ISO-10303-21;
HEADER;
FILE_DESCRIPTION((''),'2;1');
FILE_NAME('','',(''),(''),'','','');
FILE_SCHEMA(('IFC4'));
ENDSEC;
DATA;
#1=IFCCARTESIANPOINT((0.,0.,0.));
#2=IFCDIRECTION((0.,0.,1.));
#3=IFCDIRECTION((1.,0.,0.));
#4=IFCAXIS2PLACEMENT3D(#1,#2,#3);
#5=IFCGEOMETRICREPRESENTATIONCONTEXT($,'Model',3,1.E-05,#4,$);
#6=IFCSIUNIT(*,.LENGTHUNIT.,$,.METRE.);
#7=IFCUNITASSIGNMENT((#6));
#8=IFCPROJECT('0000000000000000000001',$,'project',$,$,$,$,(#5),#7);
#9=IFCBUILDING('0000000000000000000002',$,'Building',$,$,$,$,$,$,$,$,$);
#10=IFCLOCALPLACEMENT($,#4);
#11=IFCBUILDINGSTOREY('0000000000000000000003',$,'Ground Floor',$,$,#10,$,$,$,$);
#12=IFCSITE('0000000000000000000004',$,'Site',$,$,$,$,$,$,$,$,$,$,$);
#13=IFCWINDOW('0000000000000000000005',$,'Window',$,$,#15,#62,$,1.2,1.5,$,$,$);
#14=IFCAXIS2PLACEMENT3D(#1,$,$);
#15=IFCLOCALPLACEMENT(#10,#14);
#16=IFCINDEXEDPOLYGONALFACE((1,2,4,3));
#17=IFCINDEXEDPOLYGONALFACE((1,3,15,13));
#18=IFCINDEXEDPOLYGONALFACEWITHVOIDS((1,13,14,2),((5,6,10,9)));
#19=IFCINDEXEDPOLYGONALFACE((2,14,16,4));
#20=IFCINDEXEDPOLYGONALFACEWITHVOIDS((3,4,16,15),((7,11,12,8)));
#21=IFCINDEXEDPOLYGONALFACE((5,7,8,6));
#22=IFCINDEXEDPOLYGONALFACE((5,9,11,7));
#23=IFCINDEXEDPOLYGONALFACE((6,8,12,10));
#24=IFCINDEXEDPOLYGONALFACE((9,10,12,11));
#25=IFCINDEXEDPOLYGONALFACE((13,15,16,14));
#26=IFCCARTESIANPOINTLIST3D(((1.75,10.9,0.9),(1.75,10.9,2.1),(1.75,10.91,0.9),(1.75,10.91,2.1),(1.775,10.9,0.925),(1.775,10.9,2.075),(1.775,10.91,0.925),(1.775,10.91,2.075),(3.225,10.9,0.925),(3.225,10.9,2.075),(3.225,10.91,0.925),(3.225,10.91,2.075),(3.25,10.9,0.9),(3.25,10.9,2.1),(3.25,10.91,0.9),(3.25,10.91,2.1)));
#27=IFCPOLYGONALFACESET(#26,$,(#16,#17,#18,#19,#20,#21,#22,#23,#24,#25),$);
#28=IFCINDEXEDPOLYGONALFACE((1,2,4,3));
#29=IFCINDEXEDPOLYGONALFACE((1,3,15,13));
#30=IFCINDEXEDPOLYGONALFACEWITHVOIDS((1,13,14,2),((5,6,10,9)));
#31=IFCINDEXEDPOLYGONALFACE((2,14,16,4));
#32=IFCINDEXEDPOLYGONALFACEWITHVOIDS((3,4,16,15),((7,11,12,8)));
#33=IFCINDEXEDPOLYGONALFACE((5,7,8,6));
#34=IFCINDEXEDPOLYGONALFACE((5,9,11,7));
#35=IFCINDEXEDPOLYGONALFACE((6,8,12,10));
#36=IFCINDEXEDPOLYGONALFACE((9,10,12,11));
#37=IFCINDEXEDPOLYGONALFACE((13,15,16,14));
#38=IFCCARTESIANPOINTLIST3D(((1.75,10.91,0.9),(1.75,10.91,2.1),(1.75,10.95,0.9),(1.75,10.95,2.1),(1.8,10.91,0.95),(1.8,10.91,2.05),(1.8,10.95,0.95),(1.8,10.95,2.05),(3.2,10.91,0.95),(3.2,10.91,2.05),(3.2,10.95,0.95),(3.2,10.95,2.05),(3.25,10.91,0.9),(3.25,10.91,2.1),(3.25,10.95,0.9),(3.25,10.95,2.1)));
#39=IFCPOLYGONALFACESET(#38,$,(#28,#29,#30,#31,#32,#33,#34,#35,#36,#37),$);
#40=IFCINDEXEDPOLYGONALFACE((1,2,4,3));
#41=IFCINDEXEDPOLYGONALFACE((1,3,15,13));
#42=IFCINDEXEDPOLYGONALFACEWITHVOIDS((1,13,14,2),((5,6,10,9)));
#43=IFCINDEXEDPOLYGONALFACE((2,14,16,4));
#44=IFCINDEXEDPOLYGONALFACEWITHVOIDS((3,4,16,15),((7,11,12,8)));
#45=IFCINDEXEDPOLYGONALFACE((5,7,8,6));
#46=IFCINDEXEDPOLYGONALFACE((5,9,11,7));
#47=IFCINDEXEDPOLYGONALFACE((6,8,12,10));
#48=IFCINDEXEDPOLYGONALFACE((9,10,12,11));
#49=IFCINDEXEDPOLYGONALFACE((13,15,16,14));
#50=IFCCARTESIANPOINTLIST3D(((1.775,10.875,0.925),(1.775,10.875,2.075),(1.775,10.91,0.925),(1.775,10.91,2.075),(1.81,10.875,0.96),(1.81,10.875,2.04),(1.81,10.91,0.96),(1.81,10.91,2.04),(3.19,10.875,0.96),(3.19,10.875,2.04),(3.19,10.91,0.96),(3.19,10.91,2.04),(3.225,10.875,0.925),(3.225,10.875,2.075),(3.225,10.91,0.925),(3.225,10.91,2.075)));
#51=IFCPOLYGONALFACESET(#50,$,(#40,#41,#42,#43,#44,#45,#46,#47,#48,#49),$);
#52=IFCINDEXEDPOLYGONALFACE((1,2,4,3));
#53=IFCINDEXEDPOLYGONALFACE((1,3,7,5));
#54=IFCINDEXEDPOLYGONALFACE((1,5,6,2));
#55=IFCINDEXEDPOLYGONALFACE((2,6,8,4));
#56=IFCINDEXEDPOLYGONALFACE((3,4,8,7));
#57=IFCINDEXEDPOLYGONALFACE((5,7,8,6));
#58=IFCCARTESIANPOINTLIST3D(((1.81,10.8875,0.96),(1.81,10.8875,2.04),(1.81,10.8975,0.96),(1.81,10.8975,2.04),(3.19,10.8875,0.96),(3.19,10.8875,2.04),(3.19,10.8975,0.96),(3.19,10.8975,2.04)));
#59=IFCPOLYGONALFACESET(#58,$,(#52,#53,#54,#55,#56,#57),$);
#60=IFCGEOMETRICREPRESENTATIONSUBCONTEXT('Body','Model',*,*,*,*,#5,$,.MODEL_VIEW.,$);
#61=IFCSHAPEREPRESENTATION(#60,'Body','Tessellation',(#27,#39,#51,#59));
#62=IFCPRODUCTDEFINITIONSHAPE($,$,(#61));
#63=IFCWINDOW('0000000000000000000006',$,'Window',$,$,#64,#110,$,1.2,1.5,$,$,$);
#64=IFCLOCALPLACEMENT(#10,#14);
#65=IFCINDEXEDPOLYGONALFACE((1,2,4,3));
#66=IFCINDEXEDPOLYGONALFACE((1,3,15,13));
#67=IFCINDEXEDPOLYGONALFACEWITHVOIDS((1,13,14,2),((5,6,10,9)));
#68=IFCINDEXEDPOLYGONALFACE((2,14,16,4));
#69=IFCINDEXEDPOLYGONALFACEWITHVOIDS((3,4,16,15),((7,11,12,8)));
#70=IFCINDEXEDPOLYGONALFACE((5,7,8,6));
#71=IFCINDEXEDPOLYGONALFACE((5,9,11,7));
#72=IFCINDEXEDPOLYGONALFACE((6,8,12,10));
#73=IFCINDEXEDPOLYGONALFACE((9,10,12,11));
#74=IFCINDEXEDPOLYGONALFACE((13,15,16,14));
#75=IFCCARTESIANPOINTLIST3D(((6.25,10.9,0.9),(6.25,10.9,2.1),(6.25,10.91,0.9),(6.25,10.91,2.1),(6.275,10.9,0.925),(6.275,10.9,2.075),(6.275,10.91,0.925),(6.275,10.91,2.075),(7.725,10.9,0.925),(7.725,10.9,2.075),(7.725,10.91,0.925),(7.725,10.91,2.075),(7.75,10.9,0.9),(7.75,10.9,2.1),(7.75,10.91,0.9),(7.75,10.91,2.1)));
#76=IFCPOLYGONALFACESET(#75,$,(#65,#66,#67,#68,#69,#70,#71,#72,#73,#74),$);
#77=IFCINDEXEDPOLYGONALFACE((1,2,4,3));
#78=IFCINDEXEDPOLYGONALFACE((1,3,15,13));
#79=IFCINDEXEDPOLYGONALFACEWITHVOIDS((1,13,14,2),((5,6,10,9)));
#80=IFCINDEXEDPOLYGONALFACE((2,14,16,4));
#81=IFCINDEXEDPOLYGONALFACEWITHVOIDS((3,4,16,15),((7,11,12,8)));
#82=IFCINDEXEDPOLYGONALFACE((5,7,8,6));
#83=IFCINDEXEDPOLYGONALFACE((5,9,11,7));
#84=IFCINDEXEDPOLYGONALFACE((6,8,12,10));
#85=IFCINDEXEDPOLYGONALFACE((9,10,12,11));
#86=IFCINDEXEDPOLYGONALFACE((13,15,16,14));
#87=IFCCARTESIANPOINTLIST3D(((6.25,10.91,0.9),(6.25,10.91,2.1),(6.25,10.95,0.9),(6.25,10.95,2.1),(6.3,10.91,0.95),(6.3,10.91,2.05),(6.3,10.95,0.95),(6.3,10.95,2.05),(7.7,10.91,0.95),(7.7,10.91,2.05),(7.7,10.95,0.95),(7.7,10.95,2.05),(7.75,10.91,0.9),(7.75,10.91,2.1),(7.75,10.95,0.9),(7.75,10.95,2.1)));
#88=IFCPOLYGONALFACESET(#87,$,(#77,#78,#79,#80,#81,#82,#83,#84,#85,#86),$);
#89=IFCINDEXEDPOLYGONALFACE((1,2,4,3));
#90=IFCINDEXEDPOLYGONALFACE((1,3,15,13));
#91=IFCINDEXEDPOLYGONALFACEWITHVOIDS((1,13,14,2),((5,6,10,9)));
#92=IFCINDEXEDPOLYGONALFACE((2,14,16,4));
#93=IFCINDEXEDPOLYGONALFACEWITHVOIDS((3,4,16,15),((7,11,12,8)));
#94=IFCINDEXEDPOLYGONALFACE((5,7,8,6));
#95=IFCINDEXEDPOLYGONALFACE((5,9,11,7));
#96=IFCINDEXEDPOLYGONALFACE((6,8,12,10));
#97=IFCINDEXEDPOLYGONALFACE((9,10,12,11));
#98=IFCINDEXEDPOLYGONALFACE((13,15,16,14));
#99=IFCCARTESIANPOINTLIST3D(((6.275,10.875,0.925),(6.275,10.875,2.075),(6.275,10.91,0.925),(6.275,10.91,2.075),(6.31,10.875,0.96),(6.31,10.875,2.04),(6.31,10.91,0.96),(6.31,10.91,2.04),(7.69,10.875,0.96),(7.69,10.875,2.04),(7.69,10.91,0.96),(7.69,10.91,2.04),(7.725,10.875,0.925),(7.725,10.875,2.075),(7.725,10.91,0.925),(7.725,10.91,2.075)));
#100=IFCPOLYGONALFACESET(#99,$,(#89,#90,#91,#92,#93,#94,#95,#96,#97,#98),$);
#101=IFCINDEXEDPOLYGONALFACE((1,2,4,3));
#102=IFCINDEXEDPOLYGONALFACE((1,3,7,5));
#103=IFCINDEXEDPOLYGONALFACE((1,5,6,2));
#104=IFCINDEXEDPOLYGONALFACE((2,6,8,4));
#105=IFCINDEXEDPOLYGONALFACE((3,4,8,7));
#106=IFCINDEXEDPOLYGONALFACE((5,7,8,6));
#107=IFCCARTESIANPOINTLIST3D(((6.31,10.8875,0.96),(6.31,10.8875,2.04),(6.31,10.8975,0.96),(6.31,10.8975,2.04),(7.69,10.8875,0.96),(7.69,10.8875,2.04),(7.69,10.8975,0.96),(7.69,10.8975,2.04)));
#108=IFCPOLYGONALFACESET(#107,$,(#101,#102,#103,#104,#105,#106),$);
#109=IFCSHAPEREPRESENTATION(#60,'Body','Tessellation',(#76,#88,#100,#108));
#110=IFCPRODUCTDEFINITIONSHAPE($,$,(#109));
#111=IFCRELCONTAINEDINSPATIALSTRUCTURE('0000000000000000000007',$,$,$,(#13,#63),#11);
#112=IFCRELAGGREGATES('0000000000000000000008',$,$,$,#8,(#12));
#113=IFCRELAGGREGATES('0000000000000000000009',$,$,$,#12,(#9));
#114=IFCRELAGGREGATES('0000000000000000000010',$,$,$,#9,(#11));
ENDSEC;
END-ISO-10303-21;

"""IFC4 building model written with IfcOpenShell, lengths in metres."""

from ifc_helpers import new_model, si_unit, frame, origin_with_axes, place, context, subcontext, project, spatial, line, indexed_curve, outline, extrude, element, save


model = new_model("IFC4")

# Units and contexts
model_context = context("Model", 3, precision=1e-05, world=origin_with_axes())
body_context = subcontext(model_context, "Body", "Model", "MODEL_VIEW")
ifc_project = project(units=[si_unit("LENGTHUNIT", "METRE")], contexts=[model_context])

# Site, building, storey
site = spatial("IfcSite", under=ifc_project, Name="Site")
building = spatial("IfcBuilding", under=site, Name="Building")
storey_placement = place(None, origin_with_axes())
storey = spatial("IfcBuildingStorey", under=building, at=storey_placement, Name="Ground Floor")

# Windows
for number, where, z_axis, x_axis, name in (
    (1, (3.25, 11.0, 0.9), (0.0, 0.0, 1.0), (-1.0, 0.0, 0.0), "Window"),
    (2, (7.75, 11.0, 0.9), (0.0, 0.0, 1.0), (-1.0, 0.0, 0.0), "Window"),
):
    element("IfcWindow", number, at=place(storey_placement, frame(where, z_axis=z_axis, x_axis=x_axis)), inside=storey, Name=name, OverallHeight=1.2, OverallWidth=1.5, context=body_context, shape_type="SweptSolid", body=[
        extrude(outline(indexed_curve([(0.0, 0.0), (1.5, 0.0), (1.5, 1.2), (0.0, 1.2)], segments=[line(1, 2, 3, 4, 1)]), holes=[indexed_curve([(0.025, 0.025), (1.475, 0.025), (1.475, 1.175), (0.025, 1.175)], segments=[line(1, 2, 3, 4, 1)])]), frame((0.0, 0.09, 0.0), z_axis=(0.0, -1.0, 0.0), x_axis=(1.0, 0.0, 0.0)), (0.0, 0.0, -1.0), 0.01),
        extrude(outline(indexed_curve([(0.0, 0.0), (1.5, 0.0), (1.5, 1.2), (0.0, 1.2)], segments=[line(1, 2, 3, 4, 1)]), holes=[indexed_curve([(0.05, 0.05), (1.45, 0.05), (1.45, 1.15), (0.05, 1.15)], segments=[line(1, 2, 3, 4, 1)])]), frame((0.0, 0.05, 0.0), z_axis=(0.0, -1.0, 0.0), x_axis=(1.0, 0.0, 0.0)), (0.0, 0.0, -1.0), 0.04),
        extrude(outline(indexed_curve([(0.0, 0.0), (1.45, 0.0), (1.45, 1.15), (0.0, 1.15)], segments=[line(1, 2, 3, 4, 1)]), holes=[indexed_curve([(0.035, 0.035), (1.415, 0.035), (1.415, 1.115), (0.035, 1.115)], segments=[line(1, 2, 3, 4, 1)])]), frame((0.025, 0.09, 0.025), z_axis=(0.0, -1.0, 0.0), x_axis=(1.0, 0.0, 0.0)), (0.0, 0.0, -1.0), 0.035),
        extrude(outline(indexed_curve([(0.035, 0.035), (1.415, 0.035), (1.415, 1.115), (0.035, 1.115)], segments=[line(1, 2, 3, 4, 1)])), frame((0.025, 0.1025, 0.025), z_axis=(0.0, -1.0, 0.0), x_axis=(1.0, 0.0, 0.0)), (0.0, 0.0, -1.0), 0.01),
    ])

save(model, "model.ifc")
